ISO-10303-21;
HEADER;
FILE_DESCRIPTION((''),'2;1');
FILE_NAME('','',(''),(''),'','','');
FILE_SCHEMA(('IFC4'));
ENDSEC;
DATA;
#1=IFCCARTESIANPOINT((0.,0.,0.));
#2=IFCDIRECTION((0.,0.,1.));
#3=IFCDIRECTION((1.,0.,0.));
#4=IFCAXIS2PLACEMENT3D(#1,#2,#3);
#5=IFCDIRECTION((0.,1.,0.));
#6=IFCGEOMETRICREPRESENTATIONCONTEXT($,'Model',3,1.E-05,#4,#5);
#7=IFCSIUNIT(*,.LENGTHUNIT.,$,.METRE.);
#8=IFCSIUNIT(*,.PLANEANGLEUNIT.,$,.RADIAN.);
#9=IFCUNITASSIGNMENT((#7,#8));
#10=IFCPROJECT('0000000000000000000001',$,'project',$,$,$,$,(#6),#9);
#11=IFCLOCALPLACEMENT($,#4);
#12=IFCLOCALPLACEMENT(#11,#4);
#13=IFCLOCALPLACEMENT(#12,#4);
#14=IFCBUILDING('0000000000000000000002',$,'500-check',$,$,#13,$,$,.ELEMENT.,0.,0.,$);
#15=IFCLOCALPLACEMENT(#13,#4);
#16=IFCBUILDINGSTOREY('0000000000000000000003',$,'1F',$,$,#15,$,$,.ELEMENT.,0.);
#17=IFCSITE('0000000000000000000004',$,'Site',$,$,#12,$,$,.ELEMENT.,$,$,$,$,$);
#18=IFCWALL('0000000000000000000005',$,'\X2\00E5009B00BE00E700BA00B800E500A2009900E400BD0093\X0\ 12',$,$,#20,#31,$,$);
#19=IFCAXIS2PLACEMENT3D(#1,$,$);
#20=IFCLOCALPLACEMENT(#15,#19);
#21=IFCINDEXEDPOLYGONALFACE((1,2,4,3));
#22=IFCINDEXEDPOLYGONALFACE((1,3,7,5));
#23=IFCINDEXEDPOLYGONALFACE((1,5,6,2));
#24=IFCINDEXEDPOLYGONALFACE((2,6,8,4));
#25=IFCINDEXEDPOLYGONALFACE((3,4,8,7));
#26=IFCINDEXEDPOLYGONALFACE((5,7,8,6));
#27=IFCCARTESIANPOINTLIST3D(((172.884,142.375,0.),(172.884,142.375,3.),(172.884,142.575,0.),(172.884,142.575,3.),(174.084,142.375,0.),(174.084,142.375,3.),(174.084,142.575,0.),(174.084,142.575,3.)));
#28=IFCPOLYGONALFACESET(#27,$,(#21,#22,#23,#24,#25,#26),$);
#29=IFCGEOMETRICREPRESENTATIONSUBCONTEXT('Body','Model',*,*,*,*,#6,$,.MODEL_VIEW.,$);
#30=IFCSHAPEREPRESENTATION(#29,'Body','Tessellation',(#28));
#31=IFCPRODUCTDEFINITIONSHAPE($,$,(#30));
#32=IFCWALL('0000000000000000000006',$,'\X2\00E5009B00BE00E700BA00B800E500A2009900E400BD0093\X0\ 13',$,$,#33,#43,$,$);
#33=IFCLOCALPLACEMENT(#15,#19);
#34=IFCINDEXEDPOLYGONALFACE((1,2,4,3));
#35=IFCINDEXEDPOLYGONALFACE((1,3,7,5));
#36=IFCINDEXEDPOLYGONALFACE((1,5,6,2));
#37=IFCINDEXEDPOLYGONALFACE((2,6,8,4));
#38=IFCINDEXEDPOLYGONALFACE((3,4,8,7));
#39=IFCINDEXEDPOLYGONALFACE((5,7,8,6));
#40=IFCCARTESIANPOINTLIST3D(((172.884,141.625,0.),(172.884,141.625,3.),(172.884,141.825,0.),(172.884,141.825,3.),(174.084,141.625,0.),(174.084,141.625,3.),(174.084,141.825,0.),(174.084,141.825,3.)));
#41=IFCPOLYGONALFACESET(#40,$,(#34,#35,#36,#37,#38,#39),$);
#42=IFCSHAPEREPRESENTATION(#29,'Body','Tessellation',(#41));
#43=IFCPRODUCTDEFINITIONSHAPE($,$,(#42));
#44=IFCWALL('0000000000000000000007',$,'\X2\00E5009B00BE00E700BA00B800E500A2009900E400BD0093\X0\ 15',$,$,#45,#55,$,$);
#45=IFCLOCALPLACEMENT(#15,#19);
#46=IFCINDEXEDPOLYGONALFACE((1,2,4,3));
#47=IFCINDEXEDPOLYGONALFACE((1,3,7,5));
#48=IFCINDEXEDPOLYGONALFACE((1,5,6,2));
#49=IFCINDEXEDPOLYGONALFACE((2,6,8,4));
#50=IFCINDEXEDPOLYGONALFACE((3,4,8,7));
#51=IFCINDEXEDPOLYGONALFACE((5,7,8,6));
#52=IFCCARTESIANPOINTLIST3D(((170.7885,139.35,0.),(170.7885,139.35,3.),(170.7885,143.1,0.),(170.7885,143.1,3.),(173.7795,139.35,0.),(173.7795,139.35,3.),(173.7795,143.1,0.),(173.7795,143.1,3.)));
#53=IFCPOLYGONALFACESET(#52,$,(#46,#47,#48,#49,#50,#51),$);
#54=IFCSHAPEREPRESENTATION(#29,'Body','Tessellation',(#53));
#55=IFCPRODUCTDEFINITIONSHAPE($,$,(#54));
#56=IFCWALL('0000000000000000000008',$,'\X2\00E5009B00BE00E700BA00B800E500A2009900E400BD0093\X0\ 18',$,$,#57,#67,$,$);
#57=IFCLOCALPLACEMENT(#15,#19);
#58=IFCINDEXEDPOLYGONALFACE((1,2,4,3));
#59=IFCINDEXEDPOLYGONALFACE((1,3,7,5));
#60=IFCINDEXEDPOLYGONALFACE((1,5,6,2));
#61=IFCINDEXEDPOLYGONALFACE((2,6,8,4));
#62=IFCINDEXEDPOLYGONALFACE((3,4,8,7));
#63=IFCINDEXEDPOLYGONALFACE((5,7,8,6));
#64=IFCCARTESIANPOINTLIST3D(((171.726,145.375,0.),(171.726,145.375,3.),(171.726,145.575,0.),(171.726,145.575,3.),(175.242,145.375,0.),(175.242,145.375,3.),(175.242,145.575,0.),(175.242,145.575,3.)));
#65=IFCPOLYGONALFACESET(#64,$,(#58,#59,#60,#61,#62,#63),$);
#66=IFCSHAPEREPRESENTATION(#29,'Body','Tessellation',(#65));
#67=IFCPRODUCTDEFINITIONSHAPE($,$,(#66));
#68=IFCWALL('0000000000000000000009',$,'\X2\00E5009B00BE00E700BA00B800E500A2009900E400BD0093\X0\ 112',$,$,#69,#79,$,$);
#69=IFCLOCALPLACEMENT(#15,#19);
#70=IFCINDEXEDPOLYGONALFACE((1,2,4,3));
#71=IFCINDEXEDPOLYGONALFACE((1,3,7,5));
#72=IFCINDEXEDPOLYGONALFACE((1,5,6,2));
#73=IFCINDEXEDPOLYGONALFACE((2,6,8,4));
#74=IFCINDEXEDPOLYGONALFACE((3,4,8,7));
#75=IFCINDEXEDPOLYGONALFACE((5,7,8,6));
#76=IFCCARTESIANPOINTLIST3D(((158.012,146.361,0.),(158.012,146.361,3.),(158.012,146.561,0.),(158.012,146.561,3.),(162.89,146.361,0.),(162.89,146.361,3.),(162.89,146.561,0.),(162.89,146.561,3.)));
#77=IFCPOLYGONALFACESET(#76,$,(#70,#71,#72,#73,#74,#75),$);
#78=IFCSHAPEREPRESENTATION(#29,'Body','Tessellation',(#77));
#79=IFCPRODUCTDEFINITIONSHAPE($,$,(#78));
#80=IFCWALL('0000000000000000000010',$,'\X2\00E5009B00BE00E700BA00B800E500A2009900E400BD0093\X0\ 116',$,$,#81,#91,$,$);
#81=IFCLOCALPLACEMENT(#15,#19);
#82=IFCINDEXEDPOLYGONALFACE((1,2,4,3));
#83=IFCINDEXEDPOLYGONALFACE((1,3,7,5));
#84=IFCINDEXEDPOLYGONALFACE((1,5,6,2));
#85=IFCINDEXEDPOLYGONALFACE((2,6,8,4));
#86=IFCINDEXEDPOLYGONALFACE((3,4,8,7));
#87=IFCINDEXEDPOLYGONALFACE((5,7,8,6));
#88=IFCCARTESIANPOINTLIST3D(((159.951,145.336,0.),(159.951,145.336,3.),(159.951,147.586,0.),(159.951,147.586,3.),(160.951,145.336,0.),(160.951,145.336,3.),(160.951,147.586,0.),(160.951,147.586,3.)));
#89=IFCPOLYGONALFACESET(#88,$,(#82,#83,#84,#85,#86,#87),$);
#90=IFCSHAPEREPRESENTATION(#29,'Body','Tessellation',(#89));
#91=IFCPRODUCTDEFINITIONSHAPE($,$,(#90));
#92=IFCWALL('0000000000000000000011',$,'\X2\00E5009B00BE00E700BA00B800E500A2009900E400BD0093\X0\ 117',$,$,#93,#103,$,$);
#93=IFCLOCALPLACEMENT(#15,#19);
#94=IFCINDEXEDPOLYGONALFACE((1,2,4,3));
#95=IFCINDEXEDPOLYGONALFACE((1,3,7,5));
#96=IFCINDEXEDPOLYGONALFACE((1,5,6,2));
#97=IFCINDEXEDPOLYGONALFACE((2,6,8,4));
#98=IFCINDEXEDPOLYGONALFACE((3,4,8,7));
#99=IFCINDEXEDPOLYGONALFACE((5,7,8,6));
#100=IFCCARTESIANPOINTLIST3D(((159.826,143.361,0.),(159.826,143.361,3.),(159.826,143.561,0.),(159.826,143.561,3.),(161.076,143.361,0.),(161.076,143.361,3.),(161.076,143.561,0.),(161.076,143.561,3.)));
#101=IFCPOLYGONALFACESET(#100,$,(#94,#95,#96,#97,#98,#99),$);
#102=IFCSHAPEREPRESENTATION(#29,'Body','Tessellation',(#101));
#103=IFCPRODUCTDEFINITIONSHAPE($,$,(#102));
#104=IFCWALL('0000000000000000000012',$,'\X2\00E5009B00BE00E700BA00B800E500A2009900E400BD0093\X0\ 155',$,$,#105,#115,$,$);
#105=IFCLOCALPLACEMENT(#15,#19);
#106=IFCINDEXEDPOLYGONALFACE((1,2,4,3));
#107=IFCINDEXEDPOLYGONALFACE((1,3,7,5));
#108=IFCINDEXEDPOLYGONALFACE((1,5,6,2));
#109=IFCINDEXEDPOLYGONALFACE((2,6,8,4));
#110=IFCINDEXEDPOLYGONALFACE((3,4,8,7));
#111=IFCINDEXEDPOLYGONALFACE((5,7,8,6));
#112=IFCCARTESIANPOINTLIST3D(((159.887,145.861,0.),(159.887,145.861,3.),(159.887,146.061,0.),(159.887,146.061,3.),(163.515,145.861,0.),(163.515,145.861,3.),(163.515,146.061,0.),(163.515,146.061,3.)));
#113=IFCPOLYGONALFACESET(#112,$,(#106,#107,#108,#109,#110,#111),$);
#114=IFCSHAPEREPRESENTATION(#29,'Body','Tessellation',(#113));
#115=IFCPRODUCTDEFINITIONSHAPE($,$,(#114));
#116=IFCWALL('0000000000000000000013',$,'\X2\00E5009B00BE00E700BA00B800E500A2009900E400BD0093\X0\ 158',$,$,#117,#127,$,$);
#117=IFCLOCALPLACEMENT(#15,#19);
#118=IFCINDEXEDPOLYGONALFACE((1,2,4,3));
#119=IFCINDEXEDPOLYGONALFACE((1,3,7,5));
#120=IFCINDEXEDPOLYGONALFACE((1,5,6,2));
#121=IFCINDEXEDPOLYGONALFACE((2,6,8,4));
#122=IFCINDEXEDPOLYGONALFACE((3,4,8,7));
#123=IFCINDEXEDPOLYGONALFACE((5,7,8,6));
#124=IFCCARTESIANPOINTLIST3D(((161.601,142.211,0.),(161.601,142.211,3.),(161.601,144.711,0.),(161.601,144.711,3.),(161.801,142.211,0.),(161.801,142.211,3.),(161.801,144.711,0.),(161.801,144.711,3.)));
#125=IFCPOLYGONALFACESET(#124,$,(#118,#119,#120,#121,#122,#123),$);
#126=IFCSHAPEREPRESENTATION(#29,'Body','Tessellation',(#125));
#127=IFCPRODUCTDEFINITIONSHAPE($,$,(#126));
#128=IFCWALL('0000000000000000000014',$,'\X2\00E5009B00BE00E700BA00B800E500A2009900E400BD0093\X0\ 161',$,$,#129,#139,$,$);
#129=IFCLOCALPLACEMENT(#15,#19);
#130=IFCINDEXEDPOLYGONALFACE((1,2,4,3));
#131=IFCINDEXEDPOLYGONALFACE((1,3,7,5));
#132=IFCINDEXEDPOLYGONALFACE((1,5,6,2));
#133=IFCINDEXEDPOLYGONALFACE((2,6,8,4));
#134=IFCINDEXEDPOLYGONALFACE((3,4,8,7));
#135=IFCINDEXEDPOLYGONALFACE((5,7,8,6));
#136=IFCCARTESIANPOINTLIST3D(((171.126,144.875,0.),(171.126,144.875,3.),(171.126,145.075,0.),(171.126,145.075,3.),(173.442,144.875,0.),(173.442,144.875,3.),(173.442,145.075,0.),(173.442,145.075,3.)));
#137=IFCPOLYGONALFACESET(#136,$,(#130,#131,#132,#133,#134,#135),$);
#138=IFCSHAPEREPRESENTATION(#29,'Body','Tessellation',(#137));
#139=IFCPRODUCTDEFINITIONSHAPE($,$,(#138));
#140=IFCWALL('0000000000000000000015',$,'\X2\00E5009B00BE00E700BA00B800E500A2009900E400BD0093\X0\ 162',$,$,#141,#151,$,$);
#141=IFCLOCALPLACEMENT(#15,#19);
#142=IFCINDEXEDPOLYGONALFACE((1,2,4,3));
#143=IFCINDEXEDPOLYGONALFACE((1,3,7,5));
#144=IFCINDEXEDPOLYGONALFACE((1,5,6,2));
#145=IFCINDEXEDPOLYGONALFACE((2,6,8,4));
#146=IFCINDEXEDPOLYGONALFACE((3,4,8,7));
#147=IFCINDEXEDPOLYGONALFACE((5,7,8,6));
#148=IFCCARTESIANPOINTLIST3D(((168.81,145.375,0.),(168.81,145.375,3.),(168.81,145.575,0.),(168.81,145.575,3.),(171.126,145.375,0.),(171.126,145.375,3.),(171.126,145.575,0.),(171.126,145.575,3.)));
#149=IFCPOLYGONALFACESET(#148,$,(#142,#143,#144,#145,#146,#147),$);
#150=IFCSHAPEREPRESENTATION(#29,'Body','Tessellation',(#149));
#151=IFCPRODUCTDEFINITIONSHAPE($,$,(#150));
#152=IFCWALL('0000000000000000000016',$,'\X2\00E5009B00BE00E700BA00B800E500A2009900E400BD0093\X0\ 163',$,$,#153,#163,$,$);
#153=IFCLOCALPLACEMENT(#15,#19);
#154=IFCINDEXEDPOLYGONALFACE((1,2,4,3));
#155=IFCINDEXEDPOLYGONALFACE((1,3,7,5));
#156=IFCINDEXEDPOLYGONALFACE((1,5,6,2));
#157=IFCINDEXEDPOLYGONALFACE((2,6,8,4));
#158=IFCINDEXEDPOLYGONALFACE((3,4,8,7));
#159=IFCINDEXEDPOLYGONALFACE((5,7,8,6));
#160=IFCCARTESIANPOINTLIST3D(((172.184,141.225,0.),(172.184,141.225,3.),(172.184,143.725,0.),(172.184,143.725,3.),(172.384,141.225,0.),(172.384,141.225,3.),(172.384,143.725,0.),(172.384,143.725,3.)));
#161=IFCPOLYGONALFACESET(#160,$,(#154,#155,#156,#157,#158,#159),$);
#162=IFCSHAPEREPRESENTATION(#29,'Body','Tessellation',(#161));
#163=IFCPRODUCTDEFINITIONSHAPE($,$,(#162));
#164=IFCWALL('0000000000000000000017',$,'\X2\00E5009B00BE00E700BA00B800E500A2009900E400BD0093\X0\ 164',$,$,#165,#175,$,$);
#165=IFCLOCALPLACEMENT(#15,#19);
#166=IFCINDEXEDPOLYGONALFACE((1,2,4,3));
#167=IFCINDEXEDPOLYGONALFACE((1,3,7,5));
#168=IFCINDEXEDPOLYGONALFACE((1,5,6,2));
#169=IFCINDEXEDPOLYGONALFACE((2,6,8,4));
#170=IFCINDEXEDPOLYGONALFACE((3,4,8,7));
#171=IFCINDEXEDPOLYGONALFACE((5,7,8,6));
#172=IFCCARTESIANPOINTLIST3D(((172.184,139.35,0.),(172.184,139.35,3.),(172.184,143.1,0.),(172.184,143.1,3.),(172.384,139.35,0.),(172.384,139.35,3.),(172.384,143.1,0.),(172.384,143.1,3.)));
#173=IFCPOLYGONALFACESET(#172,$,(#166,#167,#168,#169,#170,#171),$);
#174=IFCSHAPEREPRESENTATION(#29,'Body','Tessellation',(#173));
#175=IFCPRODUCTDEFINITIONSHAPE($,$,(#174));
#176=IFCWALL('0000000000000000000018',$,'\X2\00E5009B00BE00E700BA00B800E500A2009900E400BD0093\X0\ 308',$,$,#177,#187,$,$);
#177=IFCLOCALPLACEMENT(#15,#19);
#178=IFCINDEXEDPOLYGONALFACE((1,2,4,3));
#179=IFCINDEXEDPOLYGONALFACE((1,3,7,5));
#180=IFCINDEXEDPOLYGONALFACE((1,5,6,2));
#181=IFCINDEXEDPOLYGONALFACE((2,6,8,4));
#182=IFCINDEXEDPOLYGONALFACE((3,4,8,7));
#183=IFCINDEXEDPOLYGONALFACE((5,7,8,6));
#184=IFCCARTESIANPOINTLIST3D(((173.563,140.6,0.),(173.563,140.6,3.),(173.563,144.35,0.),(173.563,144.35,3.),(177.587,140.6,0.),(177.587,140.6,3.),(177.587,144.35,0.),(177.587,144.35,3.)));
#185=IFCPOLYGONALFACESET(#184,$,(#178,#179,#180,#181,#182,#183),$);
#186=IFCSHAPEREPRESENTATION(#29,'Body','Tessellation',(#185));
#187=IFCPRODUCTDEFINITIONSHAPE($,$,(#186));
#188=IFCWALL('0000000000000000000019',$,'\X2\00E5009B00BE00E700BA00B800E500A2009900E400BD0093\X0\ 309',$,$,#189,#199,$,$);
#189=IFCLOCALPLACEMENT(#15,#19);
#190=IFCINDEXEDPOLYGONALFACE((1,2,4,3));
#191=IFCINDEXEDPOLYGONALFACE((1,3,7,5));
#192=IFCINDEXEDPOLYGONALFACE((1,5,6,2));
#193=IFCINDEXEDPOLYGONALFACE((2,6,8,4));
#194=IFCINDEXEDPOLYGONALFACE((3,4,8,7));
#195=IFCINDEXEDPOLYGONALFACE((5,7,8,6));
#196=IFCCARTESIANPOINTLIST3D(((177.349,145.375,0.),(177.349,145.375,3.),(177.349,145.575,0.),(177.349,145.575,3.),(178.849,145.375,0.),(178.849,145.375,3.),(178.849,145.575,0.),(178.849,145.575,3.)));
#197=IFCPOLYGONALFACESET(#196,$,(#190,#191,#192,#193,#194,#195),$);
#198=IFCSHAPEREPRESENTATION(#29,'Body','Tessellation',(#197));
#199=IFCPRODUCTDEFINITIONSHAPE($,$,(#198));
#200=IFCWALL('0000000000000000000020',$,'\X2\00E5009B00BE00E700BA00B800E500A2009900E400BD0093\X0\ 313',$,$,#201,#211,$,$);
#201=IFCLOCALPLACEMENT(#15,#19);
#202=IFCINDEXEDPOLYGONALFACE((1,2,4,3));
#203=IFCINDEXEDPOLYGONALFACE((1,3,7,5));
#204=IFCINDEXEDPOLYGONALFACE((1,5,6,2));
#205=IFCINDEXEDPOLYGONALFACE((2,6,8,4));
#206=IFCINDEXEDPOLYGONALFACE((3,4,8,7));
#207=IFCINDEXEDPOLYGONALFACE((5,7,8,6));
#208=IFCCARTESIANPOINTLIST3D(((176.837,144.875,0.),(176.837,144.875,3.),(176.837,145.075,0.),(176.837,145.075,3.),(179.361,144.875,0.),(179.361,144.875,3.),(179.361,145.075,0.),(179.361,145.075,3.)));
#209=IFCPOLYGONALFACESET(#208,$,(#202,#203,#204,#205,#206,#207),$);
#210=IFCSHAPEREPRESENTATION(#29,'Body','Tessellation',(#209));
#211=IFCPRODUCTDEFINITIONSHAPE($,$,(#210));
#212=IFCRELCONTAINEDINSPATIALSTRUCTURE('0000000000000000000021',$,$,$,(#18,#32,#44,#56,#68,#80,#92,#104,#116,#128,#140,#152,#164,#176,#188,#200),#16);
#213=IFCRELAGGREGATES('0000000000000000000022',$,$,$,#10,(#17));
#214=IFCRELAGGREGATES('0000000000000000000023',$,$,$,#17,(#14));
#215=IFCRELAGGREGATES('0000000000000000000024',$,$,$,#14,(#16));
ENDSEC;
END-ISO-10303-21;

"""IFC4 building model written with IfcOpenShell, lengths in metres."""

from ifc_helpers import new_model, si_unit, direction, frame, frame_2d, origin_with_axes, place, context, subcontext, project, spatial, rectangle, extrude, element, save


model = new_model("IFC4")

# Units and contexts
model_context = context("Model", 3, precision=1e-05, world=origin_with_axes(), true_north=direction((0.0, 1.0, 0.0)))
body_context = subcontext(model_context, "Body", "Model", "MODEL_VIEW")
ifc_project = project(units=[si_unit("LENGTHUNIT", "METRE"), si_unit("PLANEANGLEUNIT", "RADIAN")], contexts=[model_context])

# Site, building, storey
placement = place(None, origin_with_axes())
site_placement = place(placement, origin_with_axes())
site = spatial("IfcSite", under=ifc_project, at=site_placement, Name="Site", CompositionType="ELEMENT")
building_placement = place(site_placement, origin_with_axes())
building = spatial("IfcBuilding", under=site, at=building_placement, Name="500-check", CompositionType="ELEMENT", ElevationOfRefHeight=0.0, ElevationOfTerrain=0.0)
storey_placement = place(building_placement, origin_with_axes())
storey = spatial("IfcBuildingStorey", under=building, at=storey_placement, Name="1F", CompositionType="ELEMENT", Elevation=0.0)

# Walls
for number, where, z_axis, x_axis, name in (
    (1, (173.484, 142.475, 0.0), (0.0, 0.0, 1.0), (-1.0, 0.0, 0.0), "å\u009b¾çº¸å¢\u0099ä½\u0093 12"),
    (2, (173.484, 141.725, 0.0), (0.0, 0.0, 1.0), (-1.0, 0.0, 0.0), "å\u009b¾çº¸å¢\u0099ä½\u0093 13"),
):
    element("IfcWall", number, at=place(storey_placement, frame(where, z_axis=z_axis, x_axis=x_axis)), inside=storey, Name=name, context=body_context, shape_type="SweptSolid", body=[
        extrude(rectangle(XDim=1.2, YDim=0.2, at=frame_2d((0.0, 0.0), x_axis=(1.0, 0.0, 0.0))), frame((0.0, 0.0, 0.0), z_axis=(0.0, 0.0, 1.0)), (0.0, 0.0, 1.0), 3.0),
    ])
wall_1_placement = place(storey_placement, frame((172.284, 141.225, 0.0), z_axis=(0.0, 0.0, 1.0), x_axis=(1.0, 0.0, 0.0)))
element("IfcWall", 3, at=wall_1_placement, inside=storey, Name="å\u009b¾çº¸å¢\u0099ä½\u0093 15", context=body_context, shape_type="SweptSolid", body=[
    extrude(rectangle(XDim=2.991, YDim=3.75, at=frame_2d((0.0, 0.0), x_axis=(1.0, 0.0, 0.0))), frame((0.0, 0.0, 0.0), z_axis=(0.0, 0.0, 1.0)), (0.0, 0.0, 1.0), 3.0),
])
wall_2_placement = place(storey_placement, frame((173.484, 145.475, 0.0), z_axis=(0.0, 0.0, 1.0), x_axis=(-1.0, 0.0, 0.0)))
element("IfcWall", 4, at=wall_2_placement, inside=storey, Name="å\u009b¾çº¸å¢\u0099ä½\u0093 18", context=body_context, shape_type="SweptSolid", body=[
    extrude(rectangle(XDim=3.516, YDim=0.2, at=frame_2d((0.0, 0.0), x_axis=(1.0, 0.0, 0.0))), frame((0.0, 0.0, 0.0), z_axis=(0.0, 0.0, 1.0)), (0.0, 0.0, 1.0), 3.0),
])
for number, where, z_axis, x_axis, name in (
    (5, (160.451, 146.461, 0.0), (0.0, 0.0, 1.0), (1.0, 0.0, 0.0), "å\u009b¾çº¸å¢\u0099ä½\u0093 112"),
):
    element("IfcWall", number, at=place(storey_placement, frame(where, z_axis=z_axis, x_axis=x_axis)), inside=storey, Name=name, context=body_context, shape_type="SweptSolid", body=[
        extrude(rectangle(XDim=4.878, YDim=0.2, at=frame_2d((0.0, 0.0), x_axis=(1.0, 0.0, 0.0))), frame((0.0, 0.0, 0.0), z_axis=(0.0, 0.0, 1.0)), (0.0, 0.0, 1.0), 3.0),
    ])
wall_3_placement = place(storey_placement, frame((160.451, 146.461, 0.0), z_axis=(0.0, 0.0, 1.0), x_axis=(1.0, 0.0, 0.0)))
element("IfcWall", 6, at=wall_3_placement, inside=storey, Name="å\u009b¾çº¸å¢\u0099ä½\u0093 116", context=body_context, shape_type="SweptSolid", body=[
    extrude(rectangle(XDim=1.0, YDim=2.25, at=frame_2d((0.0, 0.0), x_axis=(1.0, 0.0, 0.0))), frame((0.0, 0.0, 0.0), z_axis=(0.0, 0.0, 1.0)), (0.0, 0.0, 1.0), 3.0),
])
wall_4_placement = place(storey_placement, frame((160.451, 143.461, 0.0), z_axis=(0.0, 0.0, 1.0), x_axis=(1.0, 0.0, 0.0)))
element("IfcWall", 7, at=wall_4_placement, inside=storey, Name="å\u009b¾çº¸å¢\u0099ä½\u0093 117", context=body_context, shape_type="SweptSolid", body=[
    extrude(rectangle(XDim=1.25, YDim=0.2, at=frame_2d((0.0, 0.0), x_axis=(1.0, 0.0, 0.0))), frame((0.0, 0.0, 0.0), z_axis=(0.0, 0.0, 1.0)), (0.0, 0.0, 1.0), 3.0),
])
for number, where, z_axis, x_axis, name in (
    (8, (161.701, 145.961, 0.0), (0.0, 0.0, 1.0), (1.0, 0.0, 0.0), "å\u009b¾çº¸å¢\u0099ä½\u0093 155"),
):
    element("IfcWall", number, at=place(storey_placement, frame(where, z_axis=z_axis, x_axis=x_axis)), inside=storey, Name=name, context=body_context, shape_type="SweptSolid", body=[
        extrude(rectangle(XDim=3.628, YDim=0.2, at=frame_2d((0.0, 0.0), x_axis=(1.0, 0.0, 0.0))), frame((0.0, 0.0, 0.0), z_axis=(0.0, 0.0, 1.0)), (0.0, 0.0, 1.0), 3.0),
    ])
wall_5_placement = place(storey_placement, frame((161.701, 143.461, 0.0), z_axis=(0.0, 0.0, 1.0), x_axis=(0.0, 1.0, 0.0)))
element("IfcWall", 9, at=wall_5_placement, inside=storey, Name="å\u009b¾çº¸å¢\u0099ä½\u0093 158", context=body_context, shape_type="SweptSolid", body=[
    extrude(rectangle(XDim=2.5, YDim=0.2, at=frame_2d((0.0, 0.0), x_axis=(1.0, 0.0, 0.0))), frame((0.0, 0.0, 0.0), z_axis=(0.0, 0.0, 1.0)), (0.0, 0.0, 1.0), 3.0),
])
for number, where, z_axis, x_axis, name in (
    (10, (172.284, 144.975, 0.0), (0.0, 0.0, 1.0), (-1.0, 0.0, 0.0), "å\u009b¾çº¸å¢\u0099ä½\u0093 161"),
    (11, (169.968, 145.475, 0.0), (0.0, 0.0, 1.0), (1.0, 0.0, 0.0), "å\u009b¾çº¸å¢\u0099ä½\u0093 162"),
):
    element("IfcWall", number, at=place(storey_placement, frame(where, z_axis=z_axis, x_axis=x_axis)), inside=storey, Name=name, context=body_context, shape_type="SweptSolid", body=[
        extrude(rectangle(XDim=2.316, YDim=0.2, at=frame_2d((0.0, 0.0), x_axis=(1.0, 0.0, 0.0))), frame((0.0, 0.0, 0.0), z_axis=(0.0, 0.0, 1.0)), (0.0, 0.0, 1.0), 3.0),
    ])
wall_6_placement = place(storey_placement, frame((172.284, 142.475, 0.0), z_axis=(0.0, 0.0, 1.0), x_axis=(0.0, 1.0, 0.0)))
element("IfcWall", 12, at=wall_6_placement, inside=storey, Name="å\u009b¾çº¸å¢\u0099ä½\u0093 163", context=body_context, shape_type="SweptSolid", body=[
    extrude(rectangle(XDim=2.5, YDim=0.2, at=frame_2d((0.0, 0.0), x_axis=(1.0, 0.0, 0.0))), frame((0.0, 0.0, 0.0), z_axis=(0.0, 0.0, 1.0)), (0.0, 0.0, 1.0), 3.0),
])
wall_7_placement = place(storey_placement, frame((172.284, 141.225, 0.0), z_axis=(0.0, 0.0, 1.0), x_axis=(0.0, 1.0, 0.0)))
element("IfcWall", 13, at=wall_7_placement, inside=storey, Name="å\u009b¾çº¸å¢\u0099ä½\u0093 164", context=body_context, shape_type="SweptSolid", body=[
    extrude(rectangle(XDim=3.75, YDim=0.2, at=frame_2d((0.0, 0.0), x_axis=(1.0, 0.0, 0.0))), frame((0.0, 0.0, 0.0), z_axis=(0.0, 0.0, 1.0)), (0.0, 0.0, 1.0), 3.0),
])
wall_8_placement = place(storey_placement, frame((175.575, 142.475, 0.0), z_axis=(0.0, 0.0, 1.0), x_axis=(1.0, 0.0, 0.0)))
element("IfcWall", 14, at=wall_8_placement, inside=storey, Name="å\u009b¾çº¸å¢\u0099ä½\u0093 308", context=body_context, shape_type="SweptSolid", body=[
    extrude(rectangle(XDim=4.024, YDim=3.75, at=frame_2d((0.0, 0.0), x_axis=(1.0, 0.0, 0.0))), frame((0.0, 0.0, 0.0), z_axis=(0.0, 0.0, 1.0)), (0.0, 0.0, 1.0), 3.0),
])
wall_9_placement = place(storey_placement, frame((178.099, 145.475, 0.0), z_axis=(0.0, 0.0, 1.0), x_axis=(1.0, 0.0, 0.0)))
element("IfcWall", 15, at=wall_9_placement, inside=storey, Name="å\u009b¾çº¸å¢\u0099ä½\u0093 309", context=body_context, shape_type="SweptSolid", body=[
    extrude(rectangle(XDim=1.5, YDim=0.2, at=frame_2d((0.0, 0.0), x_axis=(1.0, 0.0, 0.0))), frame((0.0, 0.0, 0.0), z_axis=(0.0, 0.0, 1.0)), (0.0, 0.0, 1.0), 3.0),
])
for number, where, z_axis, x_axis, name in (
    (16, (178.099, 144.975, 0.0), (0.0, 0.0, 1.0), (-1.0, 0.0, 0.0), "å\u009b¾çº¸å¢\u0099ä½\u0093 313"),
):
    element("IfcWall", number, at=place(storey_placement, frame(where, z_axis=z_axis, x_axis=x_axis)), inside=storey, Name=name, context=body_context, shape_type="SweptSolid", body=[
        extrude(rectangle(XDim=2.524, YDim=0.2, at=frame_2d((0.0, 0.0), x_axis=(1.0, 0.0, 0.0))), frame((0.0, 0.0, 0.0), z_axis=(0.0, 0.0, 1.0)), (0.0, 0.0, 1.0), 3.0),
    ])

save(model, "model.ifc")
